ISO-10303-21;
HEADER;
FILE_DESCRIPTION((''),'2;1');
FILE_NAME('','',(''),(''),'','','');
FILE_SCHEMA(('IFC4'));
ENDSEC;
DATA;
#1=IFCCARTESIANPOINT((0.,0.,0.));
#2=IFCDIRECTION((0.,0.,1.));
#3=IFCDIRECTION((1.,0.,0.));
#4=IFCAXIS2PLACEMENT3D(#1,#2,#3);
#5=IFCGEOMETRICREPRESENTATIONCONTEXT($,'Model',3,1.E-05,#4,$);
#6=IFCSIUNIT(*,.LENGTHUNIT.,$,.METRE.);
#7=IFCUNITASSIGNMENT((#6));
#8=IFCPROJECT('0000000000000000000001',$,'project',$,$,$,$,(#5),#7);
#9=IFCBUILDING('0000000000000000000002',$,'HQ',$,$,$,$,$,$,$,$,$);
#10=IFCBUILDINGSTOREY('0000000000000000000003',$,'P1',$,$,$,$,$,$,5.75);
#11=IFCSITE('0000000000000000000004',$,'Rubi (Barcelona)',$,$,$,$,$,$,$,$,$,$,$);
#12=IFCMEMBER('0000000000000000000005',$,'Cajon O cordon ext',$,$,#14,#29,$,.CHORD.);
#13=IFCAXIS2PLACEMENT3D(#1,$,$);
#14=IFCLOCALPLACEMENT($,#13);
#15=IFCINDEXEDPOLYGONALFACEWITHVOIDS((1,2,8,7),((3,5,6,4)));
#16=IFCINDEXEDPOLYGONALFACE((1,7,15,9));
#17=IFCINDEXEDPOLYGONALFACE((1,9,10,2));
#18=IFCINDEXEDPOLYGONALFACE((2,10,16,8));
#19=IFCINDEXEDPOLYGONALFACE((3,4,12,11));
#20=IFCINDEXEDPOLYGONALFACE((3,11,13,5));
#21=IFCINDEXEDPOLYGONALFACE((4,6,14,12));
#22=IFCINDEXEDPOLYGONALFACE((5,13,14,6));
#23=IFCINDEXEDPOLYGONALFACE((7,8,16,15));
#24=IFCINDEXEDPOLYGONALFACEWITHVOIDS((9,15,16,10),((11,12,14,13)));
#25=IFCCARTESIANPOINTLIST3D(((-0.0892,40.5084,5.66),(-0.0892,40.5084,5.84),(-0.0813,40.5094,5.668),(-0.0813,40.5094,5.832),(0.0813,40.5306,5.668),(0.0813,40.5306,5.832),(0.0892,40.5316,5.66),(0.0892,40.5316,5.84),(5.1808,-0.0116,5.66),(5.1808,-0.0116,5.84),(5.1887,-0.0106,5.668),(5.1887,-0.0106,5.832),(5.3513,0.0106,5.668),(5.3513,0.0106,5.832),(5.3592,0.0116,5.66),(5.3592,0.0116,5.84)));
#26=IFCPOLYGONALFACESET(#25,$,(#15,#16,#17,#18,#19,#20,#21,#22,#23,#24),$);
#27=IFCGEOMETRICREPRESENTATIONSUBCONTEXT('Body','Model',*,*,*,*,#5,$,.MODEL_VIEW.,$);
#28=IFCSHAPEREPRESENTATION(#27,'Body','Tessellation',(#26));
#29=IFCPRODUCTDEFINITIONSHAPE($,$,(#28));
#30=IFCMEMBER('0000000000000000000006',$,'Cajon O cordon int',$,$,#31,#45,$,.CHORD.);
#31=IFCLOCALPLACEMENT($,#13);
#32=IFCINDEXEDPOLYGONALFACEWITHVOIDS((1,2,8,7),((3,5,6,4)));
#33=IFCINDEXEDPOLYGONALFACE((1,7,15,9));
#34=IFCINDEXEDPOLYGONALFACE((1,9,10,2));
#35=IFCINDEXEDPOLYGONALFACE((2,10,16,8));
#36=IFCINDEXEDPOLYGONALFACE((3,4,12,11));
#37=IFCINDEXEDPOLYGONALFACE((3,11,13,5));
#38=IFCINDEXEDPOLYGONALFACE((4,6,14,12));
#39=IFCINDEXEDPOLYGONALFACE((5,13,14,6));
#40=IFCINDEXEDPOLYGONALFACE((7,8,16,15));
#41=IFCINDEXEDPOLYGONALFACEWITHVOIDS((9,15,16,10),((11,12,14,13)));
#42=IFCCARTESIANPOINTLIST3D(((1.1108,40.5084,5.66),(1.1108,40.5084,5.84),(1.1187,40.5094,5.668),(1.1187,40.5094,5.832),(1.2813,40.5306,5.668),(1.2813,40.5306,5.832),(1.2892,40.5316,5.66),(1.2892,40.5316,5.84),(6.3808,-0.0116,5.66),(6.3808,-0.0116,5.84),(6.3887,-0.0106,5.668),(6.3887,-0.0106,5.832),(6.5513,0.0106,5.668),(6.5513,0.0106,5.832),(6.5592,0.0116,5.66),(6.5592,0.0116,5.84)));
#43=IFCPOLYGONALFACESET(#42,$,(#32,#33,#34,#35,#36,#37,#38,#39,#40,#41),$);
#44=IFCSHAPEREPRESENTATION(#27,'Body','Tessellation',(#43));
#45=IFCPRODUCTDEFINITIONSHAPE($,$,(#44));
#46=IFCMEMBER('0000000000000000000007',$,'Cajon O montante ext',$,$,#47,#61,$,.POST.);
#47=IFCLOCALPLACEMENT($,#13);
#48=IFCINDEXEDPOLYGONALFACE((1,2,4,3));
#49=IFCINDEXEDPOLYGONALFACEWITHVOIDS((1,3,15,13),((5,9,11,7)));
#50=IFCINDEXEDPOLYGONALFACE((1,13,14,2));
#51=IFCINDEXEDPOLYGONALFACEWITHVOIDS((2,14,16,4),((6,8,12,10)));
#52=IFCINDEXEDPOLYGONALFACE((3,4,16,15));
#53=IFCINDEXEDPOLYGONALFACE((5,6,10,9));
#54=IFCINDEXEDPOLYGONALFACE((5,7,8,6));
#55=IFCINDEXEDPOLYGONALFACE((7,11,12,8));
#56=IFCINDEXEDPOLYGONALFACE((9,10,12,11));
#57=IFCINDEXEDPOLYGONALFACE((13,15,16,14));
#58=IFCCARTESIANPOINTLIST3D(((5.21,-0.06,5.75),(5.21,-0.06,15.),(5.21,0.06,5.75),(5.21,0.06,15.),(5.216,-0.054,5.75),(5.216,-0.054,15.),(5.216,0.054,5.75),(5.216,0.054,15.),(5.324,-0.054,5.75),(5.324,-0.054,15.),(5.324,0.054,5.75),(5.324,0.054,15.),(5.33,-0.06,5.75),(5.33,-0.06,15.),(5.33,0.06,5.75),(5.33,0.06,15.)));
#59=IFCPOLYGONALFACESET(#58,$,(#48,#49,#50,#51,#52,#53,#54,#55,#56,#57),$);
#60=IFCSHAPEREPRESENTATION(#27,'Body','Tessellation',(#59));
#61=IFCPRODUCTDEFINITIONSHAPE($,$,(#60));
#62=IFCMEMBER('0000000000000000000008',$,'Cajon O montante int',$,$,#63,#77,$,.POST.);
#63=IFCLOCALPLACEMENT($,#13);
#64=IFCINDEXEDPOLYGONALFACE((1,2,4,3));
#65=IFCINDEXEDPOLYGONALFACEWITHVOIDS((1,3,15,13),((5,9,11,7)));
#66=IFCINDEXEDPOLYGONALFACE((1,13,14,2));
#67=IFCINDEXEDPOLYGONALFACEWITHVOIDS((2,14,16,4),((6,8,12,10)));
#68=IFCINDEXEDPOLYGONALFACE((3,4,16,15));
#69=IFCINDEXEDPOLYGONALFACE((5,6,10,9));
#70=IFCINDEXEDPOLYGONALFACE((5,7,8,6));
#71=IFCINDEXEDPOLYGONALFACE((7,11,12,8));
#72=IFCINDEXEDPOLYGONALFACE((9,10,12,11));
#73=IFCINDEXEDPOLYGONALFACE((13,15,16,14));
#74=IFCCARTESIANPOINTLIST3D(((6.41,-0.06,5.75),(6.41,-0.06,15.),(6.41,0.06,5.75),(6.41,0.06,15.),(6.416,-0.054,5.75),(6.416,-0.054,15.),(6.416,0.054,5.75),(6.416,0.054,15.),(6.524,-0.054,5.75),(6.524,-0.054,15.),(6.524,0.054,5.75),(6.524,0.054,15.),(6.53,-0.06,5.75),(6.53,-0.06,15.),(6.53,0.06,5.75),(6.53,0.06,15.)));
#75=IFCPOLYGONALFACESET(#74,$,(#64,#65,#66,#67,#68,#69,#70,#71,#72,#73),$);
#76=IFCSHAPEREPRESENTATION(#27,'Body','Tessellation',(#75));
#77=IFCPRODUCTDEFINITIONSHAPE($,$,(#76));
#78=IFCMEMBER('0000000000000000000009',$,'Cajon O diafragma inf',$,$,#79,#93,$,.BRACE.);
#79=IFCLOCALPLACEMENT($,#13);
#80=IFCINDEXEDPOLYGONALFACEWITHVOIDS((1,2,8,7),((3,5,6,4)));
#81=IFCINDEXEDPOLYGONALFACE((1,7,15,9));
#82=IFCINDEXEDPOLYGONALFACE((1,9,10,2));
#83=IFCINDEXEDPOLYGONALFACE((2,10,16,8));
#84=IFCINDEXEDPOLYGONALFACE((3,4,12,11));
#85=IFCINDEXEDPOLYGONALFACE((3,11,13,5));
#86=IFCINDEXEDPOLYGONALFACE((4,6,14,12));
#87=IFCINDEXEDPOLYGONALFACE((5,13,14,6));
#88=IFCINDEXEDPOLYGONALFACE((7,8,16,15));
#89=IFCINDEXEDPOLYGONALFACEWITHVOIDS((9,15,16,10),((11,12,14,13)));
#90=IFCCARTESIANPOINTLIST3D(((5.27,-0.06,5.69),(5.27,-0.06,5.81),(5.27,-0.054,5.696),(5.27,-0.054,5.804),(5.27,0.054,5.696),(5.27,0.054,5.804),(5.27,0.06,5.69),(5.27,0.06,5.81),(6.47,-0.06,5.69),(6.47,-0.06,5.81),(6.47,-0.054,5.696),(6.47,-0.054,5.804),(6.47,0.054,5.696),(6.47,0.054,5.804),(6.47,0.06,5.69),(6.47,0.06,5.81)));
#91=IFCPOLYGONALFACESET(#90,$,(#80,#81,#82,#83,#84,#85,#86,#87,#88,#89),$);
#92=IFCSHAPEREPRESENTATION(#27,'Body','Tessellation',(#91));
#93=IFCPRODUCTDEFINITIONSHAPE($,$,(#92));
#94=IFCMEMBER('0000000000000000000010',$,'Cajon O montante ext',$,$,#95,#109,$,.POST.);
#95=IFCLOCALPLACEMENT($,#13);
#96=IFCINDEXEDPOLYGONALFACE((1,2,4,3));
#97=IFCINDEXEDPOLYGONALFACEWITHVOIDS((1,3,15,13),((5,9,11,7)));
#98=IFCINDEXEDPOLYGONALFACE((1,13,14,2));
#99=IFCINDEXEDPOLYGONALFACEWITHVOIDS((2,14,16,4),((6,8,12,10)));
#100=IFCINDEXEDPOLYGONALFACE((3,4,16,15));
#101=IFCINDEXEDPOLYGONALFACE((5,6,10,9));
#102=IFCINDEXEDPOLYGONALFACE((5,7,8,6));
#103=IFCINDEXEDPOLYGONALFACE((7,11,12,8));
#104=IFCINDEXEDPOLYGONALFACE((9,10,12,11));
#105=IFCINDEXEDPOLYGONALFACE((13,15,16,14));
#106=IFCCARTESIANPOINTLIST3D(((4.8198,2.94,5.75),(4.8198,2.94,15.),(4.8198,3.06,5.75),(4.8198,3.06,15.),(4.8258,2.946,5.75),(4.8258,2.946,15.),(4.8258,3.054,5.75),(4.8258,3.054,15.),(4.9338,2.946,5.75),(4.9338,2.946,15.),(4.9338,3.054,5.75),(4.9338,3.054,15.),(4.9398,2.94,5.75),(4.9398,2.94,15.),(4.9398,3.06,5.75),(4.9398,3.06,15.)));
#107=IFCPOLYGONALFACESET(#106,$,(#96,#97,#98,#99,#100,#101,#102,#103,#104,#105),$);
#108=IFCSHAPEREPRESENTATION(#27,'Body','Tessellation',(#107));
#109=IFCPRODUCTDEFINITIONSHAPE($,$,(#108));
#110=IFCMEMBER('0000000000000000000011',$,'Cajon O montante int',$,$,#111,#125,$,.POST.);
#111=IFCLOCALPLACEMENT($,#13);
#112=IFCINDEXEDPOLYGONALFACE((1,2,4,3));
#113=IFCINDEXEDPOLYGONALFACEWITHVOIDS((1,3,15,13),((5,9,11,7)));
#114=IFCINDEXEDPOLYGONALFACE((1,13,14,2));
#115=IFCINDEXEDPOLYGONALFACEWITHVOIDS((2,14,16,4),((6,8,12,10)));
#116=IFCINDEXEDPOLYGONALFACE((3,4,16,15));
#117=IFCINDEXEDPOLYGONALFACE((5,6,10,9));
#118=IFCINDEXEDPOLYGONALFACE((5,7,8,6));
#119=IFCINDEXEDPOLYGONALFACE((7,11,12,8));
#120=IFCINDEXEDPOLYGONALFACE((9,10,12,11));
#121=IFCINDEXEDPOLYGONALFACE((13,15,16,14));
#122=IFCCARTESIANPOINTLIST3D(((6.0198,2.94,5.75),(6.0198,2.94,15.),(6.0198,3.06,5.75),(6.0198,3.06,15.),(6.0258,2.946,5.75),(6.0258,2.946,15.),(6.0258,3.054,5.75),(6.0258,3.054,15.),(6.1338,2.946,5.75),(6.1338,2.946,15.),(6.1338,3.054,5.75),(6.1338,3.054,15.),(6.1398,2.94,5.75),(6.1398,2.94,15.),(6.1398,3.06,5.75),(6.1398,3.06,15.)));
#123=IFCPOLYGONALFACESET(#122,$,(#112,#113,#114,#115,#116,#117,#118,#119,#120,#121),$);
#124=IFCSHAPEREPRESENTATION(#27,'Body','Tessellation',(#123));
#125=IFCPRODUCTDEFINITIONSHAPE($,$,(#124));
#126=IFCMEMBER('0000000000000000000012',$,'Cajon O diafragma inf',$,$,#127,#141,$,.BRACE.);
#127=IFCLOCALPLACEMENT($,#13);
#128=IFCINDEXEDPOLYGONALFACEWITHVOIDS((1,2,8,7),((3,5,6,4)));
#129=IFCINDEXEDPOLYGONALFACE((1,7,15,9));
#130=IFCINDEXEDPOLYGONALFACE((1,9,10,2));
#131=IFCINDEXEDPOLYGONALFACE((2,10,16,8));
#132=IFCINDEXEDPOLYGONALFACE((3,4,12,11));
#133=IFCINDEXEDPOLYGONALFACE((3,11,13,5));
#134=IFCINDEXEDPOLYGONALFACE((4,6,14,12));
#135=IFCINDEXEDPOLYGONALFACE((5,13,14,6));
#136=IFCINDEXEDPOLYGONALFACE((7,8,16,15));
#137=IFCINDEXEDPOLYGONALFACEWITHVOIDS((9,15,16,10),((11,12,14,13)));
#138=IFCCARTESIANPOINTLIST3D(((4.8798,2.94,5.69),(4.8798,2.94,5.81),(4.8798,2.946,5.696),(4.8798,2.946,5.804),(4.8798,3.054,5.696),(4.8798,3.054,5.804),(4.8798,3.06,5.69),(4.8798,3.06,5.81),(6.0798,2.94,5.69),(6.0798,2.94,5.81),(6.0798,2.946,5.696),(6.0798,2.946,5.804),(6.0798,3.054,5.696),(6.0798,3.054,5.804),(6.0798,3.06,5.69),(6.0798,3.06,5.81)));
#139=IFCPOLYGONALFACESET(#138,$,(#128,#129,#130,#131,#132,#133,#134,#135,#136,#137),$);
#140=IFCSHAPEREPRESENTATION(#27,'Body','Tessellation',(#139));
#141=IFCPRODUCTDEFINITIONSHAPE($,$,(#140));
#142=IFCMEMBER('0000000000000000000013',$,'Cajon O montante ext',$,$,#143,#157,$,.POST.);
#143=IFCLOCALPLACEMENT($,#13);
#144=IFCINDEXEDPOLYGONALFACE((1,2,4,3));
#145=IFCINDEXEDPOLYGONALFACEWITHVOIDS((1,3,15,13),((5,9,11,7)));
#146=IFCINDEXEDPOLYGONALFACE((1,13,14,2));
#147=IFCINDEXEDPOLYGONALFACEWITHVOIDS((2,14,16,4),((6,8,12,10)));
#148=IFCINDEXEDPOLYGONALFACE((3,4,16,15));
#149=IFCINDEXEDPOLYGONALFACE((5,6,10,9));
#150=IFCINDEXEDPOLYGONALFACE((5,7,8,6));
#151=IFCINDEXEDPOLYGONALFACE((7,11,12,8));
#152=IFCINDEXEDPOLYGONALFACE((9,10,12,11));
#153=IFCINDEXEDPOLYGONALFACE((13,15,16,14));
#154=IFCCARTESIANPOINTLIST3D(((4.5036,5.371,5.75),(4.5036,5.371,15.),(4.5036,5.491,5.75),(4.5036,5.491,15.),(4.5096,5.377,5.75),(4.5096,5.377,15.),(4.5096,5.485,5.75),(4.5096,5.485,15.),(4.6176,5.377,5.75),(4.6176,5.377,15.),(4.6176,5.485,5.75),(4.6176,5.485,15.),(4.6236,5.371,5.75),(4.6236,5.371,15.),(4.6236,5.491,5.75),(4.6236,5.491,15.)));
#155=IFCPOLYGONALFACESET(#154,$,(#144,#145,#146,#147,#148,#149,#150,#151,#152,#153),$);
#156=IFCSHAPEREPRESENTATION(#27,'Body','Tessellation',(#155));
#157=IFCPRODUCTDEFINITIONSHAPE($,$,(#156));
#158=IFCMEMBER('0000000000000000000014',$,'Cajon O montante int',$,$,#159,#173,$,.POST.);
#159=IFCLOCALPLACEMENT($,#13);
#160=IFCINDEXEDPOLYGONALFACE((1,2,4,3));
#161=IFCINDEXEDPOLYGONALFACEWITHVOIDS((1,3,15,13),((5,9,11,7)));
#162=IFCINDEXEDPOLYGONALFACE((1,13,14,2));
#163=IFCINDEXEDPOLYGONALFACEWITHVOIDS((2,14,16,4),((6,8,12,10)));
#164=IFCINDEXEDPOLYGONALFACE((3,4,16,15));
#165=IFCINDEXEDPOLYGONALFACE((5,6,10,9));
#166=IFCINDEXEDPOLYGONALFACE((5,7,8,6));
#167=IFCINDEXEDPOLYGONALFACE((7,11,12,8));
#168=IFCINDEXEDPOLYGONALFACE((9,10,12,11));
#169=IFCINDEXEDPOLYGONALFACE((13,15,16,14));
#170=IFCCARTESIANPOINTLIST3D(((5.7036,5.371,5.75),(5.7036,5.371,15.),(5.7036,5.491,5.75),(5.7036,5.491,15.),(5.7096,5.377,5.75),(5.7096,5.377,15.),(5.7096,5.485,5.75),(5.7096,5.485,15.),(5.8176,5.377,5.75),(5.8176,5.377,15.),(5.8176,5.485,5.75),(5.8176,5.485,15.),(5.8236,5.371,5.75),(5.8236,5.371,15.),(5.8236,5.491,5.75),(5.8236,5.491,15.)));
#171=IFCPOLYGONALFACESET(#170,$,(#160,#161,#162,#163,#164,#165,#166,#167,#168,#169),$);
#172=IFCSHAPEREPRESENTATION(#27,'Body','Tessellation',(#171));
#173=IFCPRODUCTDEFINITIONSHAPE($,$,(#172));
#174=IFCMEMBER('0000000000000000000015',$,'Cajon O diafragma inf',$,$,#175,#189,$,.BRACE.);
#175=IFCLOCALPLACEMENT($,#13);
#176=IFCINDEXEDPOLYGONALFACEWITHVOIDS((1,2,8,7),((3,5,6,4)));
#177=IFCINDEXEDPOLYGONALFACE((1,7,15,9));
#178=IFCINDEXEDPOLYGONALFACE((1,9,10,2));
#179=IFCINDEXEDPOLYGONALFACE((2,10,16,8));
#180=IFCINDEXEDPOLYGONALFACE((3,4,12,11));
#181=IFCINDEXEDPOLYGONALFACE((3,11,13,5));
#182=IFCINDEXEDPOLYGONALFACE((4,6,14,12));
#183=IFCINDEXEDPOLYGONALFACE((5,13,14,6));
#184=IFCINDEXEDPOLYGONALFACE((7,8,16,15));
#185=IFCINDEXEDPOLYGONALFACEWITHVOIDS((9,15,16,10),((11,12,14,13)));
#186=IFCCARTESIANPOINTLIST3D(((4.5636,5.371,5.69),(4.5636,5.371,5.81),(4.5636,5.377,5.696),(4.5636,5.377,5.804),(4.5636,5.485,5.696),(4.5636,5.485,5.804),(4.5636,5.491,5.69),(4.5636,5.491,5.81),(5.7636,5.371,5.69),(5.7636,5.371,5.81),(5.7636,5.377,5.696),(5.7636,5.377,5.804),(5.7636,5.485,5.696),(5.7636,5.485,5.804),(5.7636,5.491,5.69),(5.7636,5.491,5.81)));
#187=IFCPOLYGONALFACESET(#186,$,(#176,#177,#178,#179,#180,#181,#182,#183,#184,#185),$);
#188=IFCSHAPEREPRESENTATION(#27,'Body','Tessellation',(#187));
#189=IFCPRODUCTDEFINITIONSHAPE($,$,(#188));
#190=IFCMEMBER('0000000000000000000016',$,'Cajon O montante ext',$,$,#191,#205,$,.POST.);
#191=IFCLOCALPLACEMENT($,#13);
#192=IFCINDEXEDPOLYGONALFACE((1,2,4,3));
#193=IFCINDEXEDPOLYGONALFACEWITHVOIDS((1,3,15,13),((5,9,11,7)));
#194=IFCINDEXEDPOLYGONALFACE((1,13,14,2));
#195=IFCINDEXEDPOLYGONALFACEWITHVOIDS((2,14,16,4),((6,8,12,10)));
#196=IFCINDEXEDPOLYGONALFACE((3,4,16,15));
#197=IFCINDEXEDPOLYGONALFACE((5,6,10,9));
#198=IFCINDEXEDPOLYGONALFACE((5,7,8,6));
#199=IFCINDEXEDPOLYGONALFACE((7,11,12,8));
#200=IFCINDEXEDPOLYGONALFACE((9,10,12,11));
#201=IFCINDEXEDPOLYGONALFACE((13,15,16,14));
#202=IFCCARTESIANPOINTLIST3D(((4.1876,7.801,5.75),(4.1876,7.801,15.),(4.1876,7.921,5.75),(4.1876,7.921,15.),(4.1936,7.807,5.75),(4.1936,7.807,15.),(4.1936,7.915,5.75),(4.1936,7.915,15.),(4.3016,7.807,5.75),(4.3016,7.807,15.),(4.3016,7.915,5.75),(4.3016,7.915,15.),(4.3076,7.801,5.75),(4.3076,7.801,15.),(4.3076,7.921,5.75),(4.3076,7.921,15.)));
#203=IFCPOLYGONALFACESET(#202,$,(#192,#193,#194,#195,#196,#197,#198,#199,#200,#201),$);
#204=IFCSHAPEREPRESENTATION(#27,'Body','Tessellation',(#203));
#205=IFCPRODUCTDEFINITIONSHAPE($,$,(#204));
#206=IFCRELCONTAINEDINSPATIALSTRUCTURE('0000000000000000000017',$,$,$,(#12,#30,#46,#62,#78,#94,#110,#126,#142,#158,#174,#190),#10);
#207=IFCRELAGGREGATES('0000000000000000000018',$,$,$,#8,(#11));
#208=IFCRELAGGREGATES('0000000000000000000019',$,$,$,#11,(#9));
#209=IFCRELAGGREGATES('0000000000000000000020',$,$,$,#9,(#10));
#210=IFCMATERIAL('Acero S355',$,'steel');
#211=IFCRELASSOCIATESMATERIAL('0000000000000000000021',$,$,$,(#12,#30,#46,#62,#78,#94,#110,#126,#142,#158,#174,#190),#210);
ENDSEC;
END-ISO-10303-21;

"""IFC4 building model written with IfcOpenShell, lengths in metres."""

from ifc_helpers import new_model, si_unit, frame, origin_with_axes, place, context, subcontext, project, spatial, hollow_rectangle, extrude, material, element, save


model = new_model("IFC4")

# Units and contexts
model_context = context("Model", 3, precision=1e-05, world=origin_with_axes())
body_context = subcontext(model_context, "Body", "Model", "MODEL_VIEW")
ifc_project = project(units=[si_unit("LENGTHUNIT", "METRE")], contexts=[model_context])

# Site, building, storey
site = spatial("IfcSite", under=ifc_project, Name="Rubi (Barcelona)")
building = spatial("IfcBuilding", under=site, Name="HQ")
storey = spatial("IfcBuildingStorey", under=building, Name="P1", Elevation=5.75)

# Members
ifc_material = material(Name="Acero S355", Category="steel")
member_1_placement = place(None, origin_with_axes())
element("IfcMember", 1, at=member_1_placement, inside=storey, material=ifc_material, Name="Cajon O cordon ext", PredefinedType="CHORD", context=body_context, shape_type="SweptSolid", body=[
    extrude(hollow_rectangle(XDim=0.18, YDim=0.18, WallThickness=0.008), frame((5.27, 0.0, 5.75), z_axis=(-0.128973, 0.991648, 0.0), x_axis=(-0.991648, -0.128973, 0.0)), (0.0, 0.0, 1.0), 40.8613),
])
member_2_placement = place(None, origin_with_axes())
element("IfcMember", 2, at=member_2_placement, inside=storey, material=ifc_material, Name="Cajon O cordon int", PredefinedType="CHORD", context=body_context, shape_type="SweptSolid", body=[
    extrude(hollow_rectangle(XDim=0.18, YDim=0.18, WallThickness=0.008), frame((6.47, 0.0, 5.75), z_axis=(-0.128973, 0.991648, 0.0), x_axis=(-0.991648, -0.128973, 0.0)), (0.0, 0.0, 1.0), 40.8613),
])
member_3_placement = place(None, origin_with_axes())
element("IfcMember", 3, at=member_3_placement, inside=storey, material=ifc_material, Name="Cajon O montante ext", PredefinedType="POST", context=body_context, shape_type="SweptSolid", body=[
    extrude(hollow_rectangle(XDim=0.12, YDim=0.12, WallThickness=0.006), frame((5.27, 0.0, 5.75), z_axis=(0.0, 0.0, 1.0), x_axis=(1.0, 0.0, 0.0)), (0.0, 0.0, 1.0), 9.25),
])
member_4_placement = place(None, origin_with_axes())
element("IfcMember", 4, at=member_4_placement, inside=storey, material=ifc_material, Name="Cajon O montante int", PredefinedType="POST", context=body_context, shape_type="SweptSolid", body=[
    extrude(hollow_rectangle(XDim=0.12, YDim=0.12, WallThickness=0.006), frame((6.47, 0.0, 5.75), z_axis=(0.0, 0.0, 1.0), x_axis=(1.0, 0.0, 0.0)), (0.0, 0.0, 1.0), 9.25),
])
member_5_placement = place(None, origin_with_axes())
element("IfcMember", 5, at=member_5_placement, inside=storey, material=ifc_material, Name="Cajon O diafragma inf", PredefinedType="BRACE", context=body_context, shape_type="SweptSolid", body=[
    extrude(hollow_rectangle(XDim=0.12, YDim=0.12, WallThickness=0.006), frame((5.27, 0.0, 5.75), z_axis=(1.0, 0.0, 0.0), x_axis=(0.0, 1.0, 0.0)), (0.0, 0.0, 1.0), 1.2),
])
member_6_placement = place(None, origin_with_axes())
element("IfcMember", 6, at=member_6_placement, inside=storey, material=ifc_material, Name="Cajon O montante ext", PredefinedType="POST", context=body_context, shape_type="SweptSolid", body=[
    extrude(hollow_rectangle(XDim=0.12, YDim=0.12, WallThickness=0.006), frame((4.8798, 3.0, 5.75), z_axis=(0.0, 0.0, 1.0), x_axis=(1.0, 0.0, 0.0)), (0.0, 0.0, 1.0), 9.25),
])
member_7_placement = place(None, origin_with_axes())
element("IfcMember", 7, at=member_7_placement, inside=storey, material=ifc_material, Name="Cajon O montante int", PredefinedType="POST", context=body_context, shape_type="SweptSolid", body=[
    extrude(hollow_rectangle(XDim=0.12, YDim=0.12, WallThickness=0.006), frame((6.0798, 3.0, 5.75), z_axis=(0.0, 0.0, 1.0), x_axis=(1.0, 0.0, 0.0)), (0.0, 0.0, 1.0), 9.25),
])
member_8_placement = place(None, origin_with_axes())
element("IfcMember", 8, at=member_8_placement, inside=storey, material=ifc_material, Name="Cajon O diafragma inf", PredefinedType="BRACE", context=body_context, shape_type="SweptSolid", body=[
    extrude(hollow_rectangle(XDim=0.12, YDim=0.12, WallThickness=0.006), frame((4.8798, 3.0, 5.75), z_axis=(1.0, 0.0, 0.0), x_axis=(0.0, 1.0, 0.0)), (0.0, 0.0, 1.0), 1.2),
])
member_9_placement = place(None, origin_with_axes())
element("IfcMember", 9, at=member_9_placement, inside=storey, material=ifc_material, Name="Cajon O montante ext", PredefinedType="POST", context=body_context, shape_type="SweptSolid", body=[
    extrude(hollow_rectangle(XDim=0.12, YDim=0.12, WallThickness=0.006), frame((4.5636, 5.431, 5.75), z_axis=(0.0, 0.0, 1.0), x_axis=(1.0, 0.0, 0.0)), (0.0, 0.0, 1.0), 9.25),
])
member_10_placement = place(None, origin_with_axes())
element("IfcMember", 10, at=member_10_placement, inside=storey, material=ifc_material, Name="Cajon O montante int", PredefinedType="POST", context=body_context, shape_type="SweptSolid", body=[
    extrude(hollow_rectangle(XDim=0.12, YDim=0.12, WallThickness=0.006), frame((5.7636, 5.431, 5.75), z_axis=(0.0, 0.0, 1.0), x_axis=(1.0, 0.0, 0.0)), (0.0, 0.0, 1.0), 9.25),
])
member_11_placement = place(None, origin_with_axes())
element("IfcMember", 11, at=member_11_placement, inside=storey, material=ifc_material, Name="Cajon O diafragma inf", PredefinedType="BRACE", context=body_context, shape_type="SweptSolid", body=[
    extrude(hollow_rectangle(XDim=0.12, YDim=0.12, WallThickness=0.006), frame((4.5636, 5.431, 5.75), z_axis=(1.0, 0.0, 0.0), x_axis=(0.0, 1.0, 0.0)), (0.0, 0.0, 1.0), 1.2),
])
member_12_placement = place(None, origin_with_axes())
element("IfcMember", 12, at=member_12_placement, inside=storey, material=ifc_material, Name="Cajon O montante ext", PredefinedType="POST", context=body_context, shape_type="SweptSolid", body=[
    extrude(hollow_rectangle(XDim=0.12, YDim=0.12, WallThickness=0.006), frame((4.2476, 7.861, 5.75), z_axis=(0.0, 0.0, 1.0), x_axis=(1.0, 0.0, 0.0)), (0.0, 0.0, 1.0), 9.25),
])

save(model, "model.ifc")
